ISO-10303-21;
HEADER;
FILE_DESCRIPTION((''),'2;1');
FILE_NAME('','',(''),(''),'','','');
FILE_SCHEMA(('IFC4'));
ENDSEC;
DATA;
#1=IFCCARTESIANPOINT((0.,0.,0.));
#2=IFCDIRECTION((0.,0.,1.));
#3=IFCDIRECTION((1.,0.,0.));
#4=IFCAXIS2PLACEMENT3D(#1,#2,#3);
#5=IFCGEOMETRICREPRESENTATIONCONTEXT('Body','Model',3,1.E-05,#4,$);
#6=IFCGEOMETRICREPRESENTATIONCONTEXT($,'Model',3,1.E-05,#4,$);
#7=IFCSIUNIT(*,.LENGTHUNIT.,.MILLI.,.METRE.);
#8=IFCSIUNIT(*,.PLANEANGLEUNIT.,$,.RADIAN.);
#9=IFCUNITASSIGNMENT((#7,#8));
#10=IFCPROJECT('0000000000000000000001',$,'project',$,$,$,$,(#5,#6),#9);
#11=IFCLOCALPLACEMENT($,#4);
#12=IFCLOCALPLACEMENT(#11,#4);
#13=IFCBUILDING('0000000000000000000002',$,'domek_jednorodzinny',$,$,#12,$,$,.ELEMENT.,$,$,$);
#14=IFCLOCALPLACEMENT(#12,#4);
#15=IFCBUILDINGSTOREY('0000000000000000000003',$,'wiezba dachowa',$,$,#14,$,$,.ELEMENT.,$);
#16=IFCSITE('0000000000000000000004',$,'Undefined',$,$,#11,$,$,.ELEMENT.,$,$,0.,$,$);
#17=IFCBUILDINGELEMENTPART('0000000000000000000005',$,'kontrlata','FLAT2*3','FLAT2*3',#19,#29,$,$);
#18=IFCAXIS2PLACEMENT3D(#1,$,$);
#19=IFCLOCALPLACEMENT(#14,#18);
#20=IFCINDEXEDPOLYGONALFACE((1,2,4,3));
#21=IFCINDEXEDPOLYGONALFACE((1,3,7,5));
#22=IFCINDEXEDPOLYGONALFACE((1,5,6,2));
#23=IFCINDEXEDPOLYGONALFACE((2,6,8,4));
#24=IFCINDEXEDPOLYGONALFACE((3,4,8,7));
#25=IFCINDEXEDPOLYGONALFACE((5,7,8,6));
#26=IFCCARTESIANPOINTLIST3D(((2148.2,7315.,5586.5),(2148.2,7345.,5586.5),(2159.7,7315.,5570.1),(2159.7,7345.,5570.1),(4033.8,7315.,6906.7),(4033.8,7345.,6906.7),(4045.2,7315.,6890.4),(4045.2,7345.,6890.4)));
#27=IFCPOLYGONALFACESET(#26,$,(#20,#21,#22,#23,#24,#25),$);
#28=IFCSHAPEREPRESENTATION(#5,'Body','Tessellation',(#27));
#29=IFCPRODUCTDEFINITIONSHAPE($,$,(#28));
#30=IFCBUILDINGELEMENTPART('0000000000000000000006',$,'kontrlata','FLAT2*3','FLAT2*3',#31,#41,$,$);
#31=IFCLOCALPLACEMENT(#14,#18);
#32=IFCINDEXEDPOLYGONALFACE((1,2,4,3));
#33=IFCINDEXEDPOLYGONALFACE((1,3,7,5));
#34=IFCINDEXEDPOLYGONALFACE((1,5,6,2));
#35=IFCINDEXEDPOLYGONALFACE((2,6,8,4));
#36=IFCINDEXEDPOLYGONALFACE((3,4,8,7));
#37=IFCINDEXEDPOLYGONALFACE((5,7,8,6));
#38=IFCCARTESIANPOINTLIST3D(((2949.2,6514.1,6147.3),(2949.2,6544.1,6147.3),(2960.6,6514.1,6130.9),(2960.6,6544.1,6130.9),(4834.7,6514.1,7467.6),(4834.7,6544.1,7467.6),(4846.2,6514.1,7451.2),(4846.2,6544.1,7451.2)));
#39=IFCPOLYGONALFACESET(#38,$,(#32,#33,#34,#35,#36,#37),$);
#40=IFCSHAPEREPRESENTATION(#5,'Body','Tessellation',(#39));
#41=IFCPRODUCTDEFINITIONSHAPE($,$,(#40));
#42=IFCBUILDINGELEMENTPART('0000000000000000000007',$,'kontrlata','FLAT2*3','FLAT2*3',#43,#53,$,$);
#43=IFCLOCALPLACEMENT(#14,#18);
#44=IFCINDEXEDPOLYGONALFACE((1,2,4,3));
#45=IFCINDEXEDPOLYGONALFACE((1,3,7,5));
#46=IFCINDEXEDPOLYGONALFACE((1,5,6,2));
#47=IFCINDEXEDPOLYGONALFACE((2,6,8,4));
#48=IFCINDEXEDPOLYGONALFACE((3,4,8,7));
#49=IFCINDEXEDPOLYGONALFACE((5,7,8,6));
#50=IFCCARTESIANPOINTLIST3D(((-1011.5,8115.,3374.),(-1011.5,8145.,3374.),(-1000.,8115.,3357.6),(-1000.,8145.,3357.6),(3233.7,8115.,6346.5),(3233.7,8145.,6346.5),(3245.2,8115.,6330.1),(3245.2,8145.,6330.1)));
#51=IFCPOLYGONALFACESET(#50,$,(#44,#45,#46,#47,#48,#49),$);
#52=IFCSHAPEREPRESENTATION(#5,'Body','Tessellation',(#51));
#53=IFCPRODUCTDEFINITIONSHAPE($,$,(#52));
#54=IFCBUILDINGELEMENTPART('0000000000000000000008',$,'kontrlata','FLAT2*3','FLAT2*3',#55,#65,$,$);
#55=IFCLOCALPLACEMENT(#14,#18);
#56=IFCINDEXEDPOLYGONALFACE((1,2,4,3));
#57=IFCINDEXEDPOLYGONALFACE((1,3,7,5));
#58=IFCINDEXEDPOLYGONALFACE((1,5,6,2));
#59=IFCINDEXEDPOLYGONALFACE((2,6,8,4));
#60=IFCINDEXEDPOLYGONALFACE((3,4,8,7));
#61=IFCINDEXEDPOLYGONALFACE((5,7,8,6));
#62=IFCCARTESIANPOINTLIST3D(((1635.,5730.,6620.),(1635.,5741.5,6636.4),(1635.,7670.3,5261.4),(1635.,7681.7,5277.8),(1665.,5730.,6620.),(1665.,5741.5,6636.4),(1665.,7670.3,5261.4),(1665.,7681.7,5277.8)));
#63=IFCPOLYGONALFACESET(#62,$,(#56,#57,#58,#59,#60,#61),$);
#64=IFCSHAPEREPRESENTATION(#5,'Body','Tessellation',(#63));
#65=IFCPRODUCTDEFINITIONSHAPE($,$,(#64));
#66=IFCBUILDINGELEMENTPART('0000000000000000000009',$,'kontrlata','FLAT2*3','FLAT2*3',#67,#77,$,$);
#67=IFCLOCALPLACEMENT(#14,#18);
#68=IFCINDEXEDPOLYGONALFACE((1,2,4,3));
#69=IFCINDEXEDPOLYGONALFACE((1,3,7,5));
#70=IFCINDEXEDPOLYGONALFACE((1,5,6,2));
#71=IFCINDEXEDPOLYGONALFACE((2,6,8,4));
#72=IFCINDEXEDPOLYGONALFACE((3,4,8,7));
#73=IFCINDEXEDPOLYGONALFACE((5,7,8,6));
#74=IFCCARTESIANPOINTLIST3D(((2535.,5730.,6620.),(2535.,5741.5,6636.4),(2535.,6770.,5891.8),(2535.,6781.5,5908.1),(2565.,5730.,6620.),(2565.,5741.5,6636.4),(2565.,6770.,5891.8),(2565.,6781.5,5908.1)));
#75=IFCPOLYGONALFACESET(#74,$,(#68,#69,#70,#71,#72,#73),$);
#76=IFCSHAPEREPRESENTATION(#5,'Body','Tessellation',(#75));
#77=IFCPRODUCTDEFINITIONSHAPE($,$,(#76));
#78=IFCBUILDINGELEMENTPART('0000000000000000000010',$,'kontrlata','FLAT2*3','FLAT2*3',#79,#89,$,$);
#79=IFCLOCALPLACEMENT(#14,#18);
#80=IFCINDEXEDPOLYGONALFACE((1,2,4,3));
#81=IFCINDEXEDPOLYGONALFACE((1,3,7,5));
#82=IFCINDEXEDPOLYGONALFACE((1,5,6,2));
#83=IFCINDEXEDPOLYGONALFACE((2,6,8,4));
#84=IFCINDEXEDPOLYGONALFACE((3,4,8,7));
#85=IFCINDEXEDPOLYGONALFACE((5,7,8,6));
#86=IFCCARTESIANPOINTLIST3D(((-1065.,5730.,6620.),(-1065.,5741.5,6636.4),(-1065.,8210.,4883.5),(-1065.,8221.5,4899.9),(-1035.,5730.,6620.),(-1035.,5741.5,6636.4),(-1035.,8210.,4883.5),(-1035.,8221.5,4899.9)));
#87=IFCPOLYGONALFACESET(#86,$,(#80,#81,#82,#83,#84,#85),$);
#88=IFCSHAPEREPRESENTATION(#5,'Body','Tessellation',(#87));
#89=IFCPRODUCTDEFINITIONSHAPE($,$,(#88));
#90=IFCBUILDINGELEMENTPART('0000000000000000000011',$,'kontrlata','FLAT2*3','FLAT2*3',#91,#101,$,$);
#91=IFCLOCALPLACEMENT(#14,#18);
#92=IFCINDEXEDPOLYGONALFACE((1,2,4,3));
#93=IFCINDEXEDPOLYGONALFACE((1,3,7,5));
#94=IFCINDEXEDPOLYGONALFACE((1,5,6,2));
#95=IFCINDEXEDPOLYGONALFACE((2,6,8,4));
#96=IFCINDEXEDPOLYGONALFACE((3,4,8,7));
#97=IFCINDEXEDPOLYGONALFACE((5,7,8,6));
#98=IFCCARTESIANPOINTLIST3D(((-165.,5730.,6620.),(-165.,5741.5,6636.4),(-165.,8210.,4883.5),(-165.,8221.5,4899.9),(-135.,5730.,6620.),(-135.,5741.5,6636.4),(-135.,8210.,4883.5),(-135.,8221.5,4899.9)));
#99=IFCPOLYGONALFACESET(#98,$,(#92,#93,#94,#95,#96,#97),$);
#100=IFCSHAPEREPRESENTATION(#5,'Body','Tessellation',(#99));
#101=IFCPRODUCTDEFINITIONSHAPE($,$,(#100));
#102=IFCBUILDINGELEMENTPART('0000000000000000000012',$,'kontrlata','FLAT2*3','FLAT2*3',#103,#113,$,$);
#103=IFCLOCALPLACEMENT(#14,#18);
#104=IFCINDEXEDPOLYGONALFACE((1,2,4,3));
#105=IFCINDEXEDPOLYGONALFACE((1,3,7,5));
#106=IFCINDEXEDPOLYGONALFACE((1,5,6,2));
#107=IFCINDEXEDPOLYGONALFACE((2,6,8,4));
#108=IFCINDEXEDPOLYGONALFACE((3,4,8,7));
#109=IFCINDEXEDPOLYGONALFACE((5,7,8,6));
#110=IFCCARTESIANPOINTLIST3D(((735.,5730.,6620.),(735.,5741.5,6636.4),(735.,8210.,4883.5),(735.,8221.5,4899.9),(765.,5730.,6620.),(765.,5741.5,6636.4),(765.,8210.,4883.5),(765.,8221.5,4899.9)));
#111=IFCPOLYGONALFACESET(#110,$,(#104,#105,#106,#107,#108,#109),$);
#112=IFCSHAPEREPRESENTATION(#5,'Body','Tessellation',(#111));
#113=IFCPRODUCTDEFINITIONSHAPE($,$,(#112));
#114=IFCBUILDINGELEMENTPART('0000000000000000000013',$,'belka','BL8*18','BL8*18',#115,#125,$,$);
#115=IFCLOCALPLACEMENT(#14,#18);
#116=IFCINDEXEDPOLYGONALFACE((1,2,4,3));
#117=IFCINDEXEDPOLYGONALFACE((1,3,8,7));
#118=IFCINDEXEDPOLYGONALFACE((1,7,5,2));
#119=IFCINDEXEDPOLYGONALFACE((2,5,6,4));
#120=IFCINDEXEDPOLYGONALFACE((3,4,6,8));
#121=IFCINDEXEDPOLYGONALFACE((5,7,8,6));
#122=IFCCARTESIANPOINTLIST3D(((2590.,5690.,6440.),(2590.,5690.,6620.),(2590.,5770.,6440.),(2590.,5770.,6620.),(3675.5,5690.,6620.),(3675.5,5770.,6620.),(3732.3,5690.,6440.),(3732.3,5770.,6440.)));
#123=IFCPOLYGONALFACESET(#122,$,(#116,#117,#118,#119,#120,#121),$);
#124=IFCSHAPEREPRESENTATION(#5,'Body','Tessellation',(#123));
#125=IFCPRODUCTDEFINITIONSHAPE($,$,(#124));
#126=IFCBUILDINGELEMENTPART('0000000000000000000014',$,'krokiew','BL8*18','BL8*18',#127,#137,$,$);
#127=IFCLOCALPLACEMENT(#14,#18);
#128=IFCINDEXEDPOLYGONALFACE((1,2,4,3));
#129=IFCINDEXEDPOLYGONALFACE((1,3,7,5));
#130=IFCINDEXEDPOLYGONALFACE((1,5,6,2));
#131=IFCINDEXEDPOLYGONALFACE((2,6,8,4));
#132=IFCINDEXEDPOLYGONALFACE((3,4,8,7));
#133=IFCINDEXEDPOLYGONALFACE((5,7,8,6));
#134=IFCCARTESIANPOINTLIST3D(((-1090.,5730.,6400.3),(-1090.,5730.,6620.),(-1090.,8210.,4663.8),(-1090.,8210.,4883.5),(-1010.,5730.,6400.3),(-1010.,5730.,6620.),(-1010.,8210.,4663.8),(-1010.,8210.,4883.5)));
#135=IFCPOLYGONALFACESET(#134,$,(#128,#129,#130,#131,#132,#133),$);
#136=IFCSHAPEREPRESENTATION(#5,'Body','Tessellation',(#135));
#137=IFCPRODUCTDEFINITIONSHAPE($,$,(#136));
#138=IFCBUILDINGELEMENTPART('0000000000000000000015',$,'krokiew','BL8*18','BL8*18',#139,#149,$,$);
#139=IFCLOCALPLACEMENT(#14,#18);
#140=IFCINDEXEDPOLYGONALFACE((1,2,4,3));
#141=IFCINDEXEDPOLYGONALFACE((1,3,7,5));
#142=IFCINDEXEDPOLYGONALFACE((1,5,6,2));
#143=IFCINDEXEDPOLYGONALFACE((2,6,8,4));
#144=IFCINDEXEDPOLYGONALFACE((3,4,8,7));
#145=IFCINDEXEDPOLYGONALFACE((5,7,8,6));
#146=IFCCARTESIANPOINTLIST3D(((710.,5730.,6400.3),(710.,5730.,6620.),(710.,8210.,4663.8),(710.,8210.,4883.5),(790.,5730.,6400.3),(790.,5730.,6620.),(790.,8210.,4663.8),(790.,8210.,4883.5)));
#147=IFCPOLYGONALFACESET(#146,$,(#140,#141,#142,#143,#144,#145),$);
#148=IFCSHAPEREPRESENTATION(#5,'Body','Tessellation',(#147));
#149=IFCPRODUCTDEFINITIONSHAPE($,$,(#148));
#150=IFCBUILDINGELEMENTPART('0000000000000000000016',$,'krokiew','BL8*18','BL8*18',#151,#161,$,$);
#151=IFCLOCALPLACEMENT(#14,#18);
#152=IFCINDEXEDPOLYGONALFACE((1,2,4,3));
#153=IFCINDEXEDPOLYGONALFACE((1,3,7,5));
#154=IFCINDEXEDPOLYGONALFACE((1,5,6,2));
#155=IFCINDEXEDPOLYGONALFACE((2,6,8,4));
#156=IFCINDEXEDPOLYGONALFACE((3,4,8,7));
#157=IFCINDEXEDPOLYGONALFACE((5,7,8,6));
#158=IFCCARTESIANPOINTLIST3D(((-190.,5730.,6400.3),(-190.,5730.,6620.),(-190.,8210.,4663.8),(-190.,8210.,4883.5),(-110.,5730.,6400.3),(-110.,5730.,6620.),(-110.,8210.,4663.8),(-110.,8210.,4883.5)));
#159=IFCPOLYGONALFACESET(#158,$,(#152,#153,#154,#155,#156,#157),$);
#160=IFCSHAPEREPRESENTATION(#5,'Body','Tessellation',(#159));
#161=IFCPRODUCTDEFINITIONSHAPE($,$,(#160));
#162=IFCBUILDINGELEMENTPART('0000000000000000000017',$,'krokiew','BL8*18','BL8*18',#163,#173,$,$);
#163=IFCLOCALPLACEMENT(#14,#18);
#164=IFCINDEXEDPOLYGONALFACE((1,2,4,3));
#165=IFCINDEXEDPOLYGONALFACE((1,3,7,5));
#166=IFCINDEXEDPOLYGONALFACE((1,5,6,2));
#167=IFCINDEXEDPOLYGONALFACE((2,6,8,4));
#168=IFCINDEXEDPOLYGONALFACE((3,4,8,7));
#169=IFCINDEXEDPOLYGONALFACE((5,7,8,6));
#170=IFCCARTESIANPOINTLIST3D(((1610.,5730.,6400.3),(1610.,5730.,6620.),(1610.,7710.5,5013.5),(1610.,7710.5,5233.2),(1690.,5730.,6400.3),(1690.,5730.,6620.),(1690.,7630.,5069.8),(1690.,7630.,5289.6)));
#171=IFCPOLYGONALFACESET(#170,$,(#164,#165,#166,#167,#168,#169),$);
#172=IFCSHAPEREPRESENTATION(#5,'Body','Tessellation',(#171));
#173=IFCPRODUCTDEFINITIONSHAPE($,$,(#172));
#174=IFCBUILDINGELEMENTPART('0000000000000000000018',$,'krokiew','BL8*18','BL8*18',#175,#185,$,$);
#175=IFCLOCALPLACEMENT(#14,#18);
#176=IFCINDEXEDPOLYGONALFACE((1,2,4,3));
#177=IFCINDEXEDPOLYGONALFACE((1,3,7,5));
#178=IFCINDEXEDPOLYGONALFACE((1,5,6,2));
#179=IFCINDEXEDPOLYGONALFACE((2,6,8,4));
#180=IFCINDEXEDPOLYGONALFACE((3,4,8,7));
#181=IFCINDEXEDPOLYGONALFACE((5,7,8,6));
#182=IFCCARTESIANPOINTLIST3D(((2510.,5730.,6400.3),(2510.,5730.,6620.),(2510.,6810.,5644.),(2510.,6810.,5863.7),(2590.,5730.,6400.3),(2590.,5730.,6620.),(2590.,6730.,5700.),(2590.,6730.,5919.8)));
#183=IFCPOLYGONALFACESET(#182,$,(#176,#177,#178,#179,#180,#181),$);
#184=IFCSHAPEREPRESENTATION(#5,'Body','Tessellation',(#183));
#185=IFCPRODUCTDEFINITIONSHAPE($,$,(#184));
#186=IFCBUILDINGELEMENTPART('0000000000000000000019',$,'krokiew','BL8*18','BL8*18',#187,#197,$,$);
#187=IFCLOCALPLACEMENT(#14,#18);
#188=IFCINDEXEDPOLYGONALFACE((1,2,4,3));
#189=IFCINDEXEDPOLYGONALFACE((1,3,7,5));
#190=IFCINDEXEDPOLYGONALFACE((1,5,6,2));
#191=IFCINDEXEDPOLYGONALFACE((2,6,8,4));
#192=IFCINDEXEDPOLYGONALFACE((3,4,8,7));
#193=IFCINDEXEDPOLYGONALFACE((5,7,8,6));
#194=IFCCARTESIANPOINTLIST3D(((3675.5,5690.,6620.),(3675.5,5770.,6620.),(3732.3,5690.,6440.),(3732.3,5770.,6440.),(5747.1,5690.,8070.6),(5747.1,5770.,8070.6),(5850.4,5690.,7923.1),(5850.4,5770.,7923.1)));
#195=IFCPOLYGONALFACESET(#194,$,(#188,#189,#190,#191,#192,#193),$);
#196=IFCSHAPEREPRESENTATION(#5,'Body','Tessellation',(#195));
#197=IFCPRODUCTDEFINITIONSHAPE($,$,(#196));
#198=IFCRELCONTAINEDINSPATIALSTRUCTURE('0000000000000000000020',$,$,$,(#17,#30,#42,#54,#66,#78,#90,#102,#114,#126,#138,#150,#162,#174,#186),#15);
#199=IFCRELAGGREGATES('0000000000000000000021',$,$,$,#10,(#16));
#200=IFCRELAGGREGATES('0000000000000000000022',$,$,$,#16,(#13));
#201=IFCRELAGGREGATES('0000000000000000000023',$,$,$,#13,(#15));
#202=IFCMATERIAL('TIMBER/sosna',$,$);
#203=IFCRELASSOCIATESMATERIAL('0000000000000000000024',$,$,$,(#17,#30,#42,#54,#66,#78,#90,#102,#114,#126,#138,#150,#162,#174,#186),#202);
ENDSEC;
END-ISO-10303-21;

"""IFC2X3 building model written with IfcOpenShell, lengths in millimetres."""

from ifc_helpers import new_model, si_unit, frame, origin_with_axes, origin_2d_with_axis, place, context, project, spatial, rectangle, extrude, clip, halfspace, material, element, save


model = new_model("IFC2X3")

# Units and contexts
model_context_1 = context("Model", 3, precision=1e-05, world=origin_with_axes(), identifier="Body")
model_context_2 = context("Model", 3, precision=1e-05, world=origin_with_axes())
ifc_project = project(units=[si_unit("LENGTHUNIT", "METRE", prefix="MILLI"), si_unit("PLANEANGLEUNIT", "RADIAN")], contexts=[model_context_1, model_context_2])

# Site, building, storey
site_placement = place(None, origin_with_axes())
site = spatial("IfcSite", under=ifc_project, at=site_placement, Name="Undefined", CompositionType="ELEMENT", RefElevation=0.0)
building_placement = place(site_placement, origin_with_axes())
building = spatial("IfcBuilding", under=site, at=building_placement, Name="domek_jednorodzinny", CompositionType="ELEMENT")
storey_placement = place(building_placement, origin_with_axes())
storey = spatial("IfcBuildingStorey", under=building, at=storey_placement, Name="wiezba dachowa", CompositionType="ELEMENT")

# Building element parts
ifc_material = material(Name="TIMBER/sosna")
for number, where, z_axis, x_axis, name in (
    (1, (2154.0, 7330.0, 5578.3), (0.0, -1.0, 0.0), (0.819152, 0.0, 0.573576), "kontrlata"),
    (2, (2954.9, 6529.1, 6139.1), (0.0, -1.0, 0.0), (0.819152, 0.0, 0.573576), "kontrlata"),
):
    element("IfcBuildingElementPart", number, at=place(storey_placement, frame(where, z_axis=z_axis, x_axis=x_axis)), inside=storey, material=ifc_material, Name=name, Description="FLAT2*3", ObjectType="FLAT2*3", context=model_context_1, shape_type="SweptSolid", body=[
        extrude(rectangle(XDim=20.0, YDim=30.0, at=origin_2d_with_axis()), frame((2301.8, 0.0, 0.0), z_axis=(-1.0, 0.0, 0.0), x_axis=(0.0, -1.0, 0.0)), (0.0, 0.0, 1.0), 2301.8),
    ])
building_element_part_1_placement = place(storey_placement, frame((-1005.7, 8130.0, 3365.8), z_axis=(0.0, -1.0, 0.0), x_axis=(0.819152, 0.0, 0.573576)))
element("IfcBuildingElementPart", 3, at=building_element_part_1_placement, inside=storey, material=ifc_material, Name="kontrlata", Description="FLAT2*3", ObjectType="FLAT2*3", context=model_context_1, shape_type="SweptSolid", body=[
    extrude(rectangle(XDim=20.0, YDim=30.0, at=origin_2d_with_axis()), frame((5182.4, 0.0, 0.0), z_axis=(-1.0, 0.0, 0.0), x_axis=(0.0, -1.0, 0.0)), (0.0, 0.0, 1.0), 5182.4),
])
building_element_part_2_placement = place(storey_placement, frame((1650.0, 7676.0, 5269.6), z_axis=(-1.0, 0.0, 0.0), x_axis=(0.0, -0.819154, 0.573574)))
element("IfcBuildingElementPart", 4, at=building_element_part_2_placement, inside=storey, material=ifc_material, Name="kontrlata", Description="FLAT2*3", ObjectType="FLAT2*3", context=model_context_1, shape_type="SweptSolid", body=[
    extrude(rectangle(XDim=20.0, YDim=30.0, at=origin_2d_with_axis()), frame((2368.6, 0.0, 0.0), z_axis=(-1.0, 0.0, 0.0), x_axis=(0.0, -1.0, 0.0)), (0.0, 0.0, 1.0), 2368.6),
])
building_element_part_3_placement = place(storey_placement, frame((2550.0, 6775.8, 5900.0), z_axis=(-1.0, 0.0, 0.0), x_axis=(0.0, -0.819154, 0.573574)))
element("IfcBuildingElementPart", 5, at=building_element_part_3_placement, inside=storey, material=ifc_material, Name="kontrlata", Description="FLAT2*3", ObjectType="FLAT2*3", context=model_context_1, shape_type="SweptSolid", body=[
    extrude(rectangle(XDim=20.0, YDim=30.0, at=origin_2d_with_axis()), frame((1269.7, 0.0, 0.0), z_axis=(-1.0, 0.0, 0.0), x_axis=(0.0, -1.0, 0.0)), (0.0, 0.0, 1.0), 1269.7),
])
for number, where, z_axis, x_axis, name in (
    (6, (-1050.0, 8215.8, 4891.7), (1.0, 0.0, 0.0), (0.0, -0.819154, 0.573574), "kontrlata"),
    (7, (-150.0, 8215.8, 4891.7), (1.0, 0.0, 0.0), (0.0, -0.819154, 0.573574), "kontrlata"),
    (8, (750.0, 8215.8, 4891.7), (1.0, 0.0, 0.0), (0.0, -0.819154, 0.573574), "kontrlata"),
):
    element("IfcBuildingElementPart", number, at=place(storey_placement, frame(where, z_axis=z_axis, x_axis=x_axis)), inside=storey, material=ifc_material, Name=name, Description="FLAT2*3", ObjectType="FLAT2*3", context=model_context_1, shape_type="SweptSolid", body=[
        extrude(rectangle(XDim=20.0, YDim=30.0, at=origin_2d_with_axis()), frame((3027.6, 0.0, 0.0), z_axis=(-1.0, 0.0, 0.0), x_axis=(0.0, -1.0, 0.0)), (0.0, 0.0, 1.0), 3027.6),
    ])
building_element_part_4_placement = place(storey_placement, frame((2590.0, 5730.0, 6530.0), z_axis=(0.0, 0.0, 1.0), x_axis=(1.0, 0.0, 0.0)))
element("IfcBuildingElementPart", 9, at=building_element_part_4_placement, inside=storey, material=ifc_material, Name="belka", Description="BL8*18", ObjectType="BL8*18", context=model_context_1, shape_type="Clipping", body=[
    clip(extrude(rectangle(XDim=80.0, YDim=180.0, at=origin_2d_with_axis()), frame((1230.0, 0.0, 0.0), z_axis=(-1.0, 0.0, 0.0), x_axis=(0.0, -1.0, 0.0)), (0.0, 0.0, 1.0), 1230.0), halfspace(frame((1142.3, -40.0, -90.0), z_axis=(0.953717, 0.0, 0.300706), x_axis=(-0.300706, 0.0, 0.953717)), False)),
])
for number, where, z_axis, x_axis, name in (
    (10, (-1050.0, 5678.4, 6546.3), (0.0, 0.573576, 0.819152), (0.0, 0.819154, -0.573574), "krokiew"),
    (11, (750.0, 5678.4, 6546.3), (0.0, 0.573576, 0.819152), (0.0, 0.819154, -0.573574), "krokiew"),
    (12, (-150.0, 5678.4, 6546.3), (0.0, 0.573576, 0.819152), (0.0, 0.819154, -0.573574), "krokiew"),
):
    element("IfcBuildingElementPart", number, at=place(storey_placement, frame(where, z_axis=z_axis, x_axis=x_axis)), inside=storey, material=ifc_material, Name=name, Description="BL8*18", ObjectType="BL8*18", context=model_context_1, shape_type="Clipping", body=[
        clip(clip(extrude(rectangle(XDim=80.0, YDim=180.0, at=origin_2d_with_axis()), frame((3727.3, 0.0, 0.0), z_axis=(-1.0, 0.0, 0.0), x_axis=(0.0, -1.0, 0.0)), (0.0, 0.0, 1.0), 3727.3), halfspace(frame((126.0, 40.0, -90.0), z_axis=(-0.819149, 0.0, -0.573581), x_axis=(-0.573576, 0.0, 0.819152)), False)), halfspace(frame((3342.3, -40.0, -359.6), z_axis=(0.819152, 0.0, 0.573576), x_axis=(-0.573576, 0.0, 0.819152)), False)),
    ])
building_element_part_5_placement = place(storey_placement, frame((1650.0, 5678.4, 6546.3), z_axis=(0.0, 0.573576, 0.819152), x_axis=(0.0, 0.819154, -0.573574)))
element("IfcBuildingElementPart", 13, at=building_element_part_5_placement, inside=storey, material=ifc_material, Name="krokiew", Description="BL8*18", ObjectType="BL8*18", context=model_context_1, shape_type="Clipping", body=[
    clip(clip(clip(extrude(rectangle(XDim=80.0, YDim=180.0, at=origin_2d_with_axis()), frame((3727.3, 0.0, 0.0), z_axis=(-1.0, 0.0, 0.0), x_axis=(0.0, -1.0, 0.0)), (0.0, 0.0, 1.0), 3727.3), halfspace(frame((126.0, 40.0, -90.0), z_axis=(-0.819149, 0.0, -0.573581), x_axis=(-0.573576, 0.0, 0.819152)), False)), halfspace(frame((3710.9, -40.0, -101.5), z_axis=(0.819152, 0.0, 0.573576), x_axis=(-0.573576, 0.0, 0.819152)), False)), halfspace(frame((2445.6, -40.0, -90.0), z_axis=(0.577612, -0.709076, 0.404445), x_axis=(-0.573576, 0.0, 0.819152)), False)),
])
building_element_part_6_placement = place(storey_placement, frame((2550.0, 5678.4, 6546.3), z_axis=(0.0, 0.573576, 0.819152), x_axis=(0.0, 0.819154, -0.573574)))
element("IfcBuildingElementPart", 14, at=building_element_part_6_placement, inside=storey, material=ifc_material, Name="krokiew", Description="BL8*18", ObjectType="BL8*18", context=model_context_1, shape_type="Clipping", body=[
    clip(clip(clip(extrude(rectangle(XDim=80.0, YDim=180.0, at=origin_2d_with_axis()), frame((3727.3, 0.0, 0.0), z_axis=(-1.0, 0.0, 0.0), x_axis=(0.0, -1.0, 0.0)), (0.0, 0.0, 1.0), 3727.3), halfspace(frame((126.0, 40.0, -90.0), z_axis=(-0.819149, 0.0, -0.573581), x_axis=(-0.573576, 0.0, 0.819152)), False)), halfspace(frame((3710.9, -40.0, -101.5), z_axis=(0.819152, 0.0, 0.573576), x_axis=(-0.573576, 0.0, 0.819152)), False)), halfspace(frame((1346.9, -40.0, -90.0), z_axis=(0.579227, -0.707107, 0.405581), x_axis=(-0.573576, 0.0, 0.819152)), False)),
])
building_element_part_7_placement = place(storey_placement, frame((-706.8, 5730.0, 3441.6), z_axis=(-0.573576, 0.0, 0.819152), x_axis=(0.819152, 0.0, 0.573576)))
element("IfcBuildingElementPart", 15, at=building_element_part_7_placement, inside=storey, material=ifc_material, Name="krokiew", Description="BL8*18", ObjectType="BL8*18", context=model_context_1, shape_type="Clipping", body=[
    clip(clip(extrude(rectangle(XDim=80.0, YDim=180.0, at=origin_2d_with_axis()), frame((7941.8, 0.0, 0.0), z_axis=(-1.0, 0.0, 0.0), x_axis=(0.0, -1.0, 0.0)), (0.0, 0.0, 1.0), 7941.8), halfspace(frame((0.0, 40.0, -90.0), z_axis=(-0.819152, 0.0, 0.573576), x_axis=(0.573578, 0.0, 0.819151)), False)), halfspace(frame((5356.1, 40.0, -90.0), z_axis=(-0.953717, 0.0, 0.300706), x_axis=(0.300706, 0.0, 0.953717)), False)),
])

save(model, "model.ifc")
